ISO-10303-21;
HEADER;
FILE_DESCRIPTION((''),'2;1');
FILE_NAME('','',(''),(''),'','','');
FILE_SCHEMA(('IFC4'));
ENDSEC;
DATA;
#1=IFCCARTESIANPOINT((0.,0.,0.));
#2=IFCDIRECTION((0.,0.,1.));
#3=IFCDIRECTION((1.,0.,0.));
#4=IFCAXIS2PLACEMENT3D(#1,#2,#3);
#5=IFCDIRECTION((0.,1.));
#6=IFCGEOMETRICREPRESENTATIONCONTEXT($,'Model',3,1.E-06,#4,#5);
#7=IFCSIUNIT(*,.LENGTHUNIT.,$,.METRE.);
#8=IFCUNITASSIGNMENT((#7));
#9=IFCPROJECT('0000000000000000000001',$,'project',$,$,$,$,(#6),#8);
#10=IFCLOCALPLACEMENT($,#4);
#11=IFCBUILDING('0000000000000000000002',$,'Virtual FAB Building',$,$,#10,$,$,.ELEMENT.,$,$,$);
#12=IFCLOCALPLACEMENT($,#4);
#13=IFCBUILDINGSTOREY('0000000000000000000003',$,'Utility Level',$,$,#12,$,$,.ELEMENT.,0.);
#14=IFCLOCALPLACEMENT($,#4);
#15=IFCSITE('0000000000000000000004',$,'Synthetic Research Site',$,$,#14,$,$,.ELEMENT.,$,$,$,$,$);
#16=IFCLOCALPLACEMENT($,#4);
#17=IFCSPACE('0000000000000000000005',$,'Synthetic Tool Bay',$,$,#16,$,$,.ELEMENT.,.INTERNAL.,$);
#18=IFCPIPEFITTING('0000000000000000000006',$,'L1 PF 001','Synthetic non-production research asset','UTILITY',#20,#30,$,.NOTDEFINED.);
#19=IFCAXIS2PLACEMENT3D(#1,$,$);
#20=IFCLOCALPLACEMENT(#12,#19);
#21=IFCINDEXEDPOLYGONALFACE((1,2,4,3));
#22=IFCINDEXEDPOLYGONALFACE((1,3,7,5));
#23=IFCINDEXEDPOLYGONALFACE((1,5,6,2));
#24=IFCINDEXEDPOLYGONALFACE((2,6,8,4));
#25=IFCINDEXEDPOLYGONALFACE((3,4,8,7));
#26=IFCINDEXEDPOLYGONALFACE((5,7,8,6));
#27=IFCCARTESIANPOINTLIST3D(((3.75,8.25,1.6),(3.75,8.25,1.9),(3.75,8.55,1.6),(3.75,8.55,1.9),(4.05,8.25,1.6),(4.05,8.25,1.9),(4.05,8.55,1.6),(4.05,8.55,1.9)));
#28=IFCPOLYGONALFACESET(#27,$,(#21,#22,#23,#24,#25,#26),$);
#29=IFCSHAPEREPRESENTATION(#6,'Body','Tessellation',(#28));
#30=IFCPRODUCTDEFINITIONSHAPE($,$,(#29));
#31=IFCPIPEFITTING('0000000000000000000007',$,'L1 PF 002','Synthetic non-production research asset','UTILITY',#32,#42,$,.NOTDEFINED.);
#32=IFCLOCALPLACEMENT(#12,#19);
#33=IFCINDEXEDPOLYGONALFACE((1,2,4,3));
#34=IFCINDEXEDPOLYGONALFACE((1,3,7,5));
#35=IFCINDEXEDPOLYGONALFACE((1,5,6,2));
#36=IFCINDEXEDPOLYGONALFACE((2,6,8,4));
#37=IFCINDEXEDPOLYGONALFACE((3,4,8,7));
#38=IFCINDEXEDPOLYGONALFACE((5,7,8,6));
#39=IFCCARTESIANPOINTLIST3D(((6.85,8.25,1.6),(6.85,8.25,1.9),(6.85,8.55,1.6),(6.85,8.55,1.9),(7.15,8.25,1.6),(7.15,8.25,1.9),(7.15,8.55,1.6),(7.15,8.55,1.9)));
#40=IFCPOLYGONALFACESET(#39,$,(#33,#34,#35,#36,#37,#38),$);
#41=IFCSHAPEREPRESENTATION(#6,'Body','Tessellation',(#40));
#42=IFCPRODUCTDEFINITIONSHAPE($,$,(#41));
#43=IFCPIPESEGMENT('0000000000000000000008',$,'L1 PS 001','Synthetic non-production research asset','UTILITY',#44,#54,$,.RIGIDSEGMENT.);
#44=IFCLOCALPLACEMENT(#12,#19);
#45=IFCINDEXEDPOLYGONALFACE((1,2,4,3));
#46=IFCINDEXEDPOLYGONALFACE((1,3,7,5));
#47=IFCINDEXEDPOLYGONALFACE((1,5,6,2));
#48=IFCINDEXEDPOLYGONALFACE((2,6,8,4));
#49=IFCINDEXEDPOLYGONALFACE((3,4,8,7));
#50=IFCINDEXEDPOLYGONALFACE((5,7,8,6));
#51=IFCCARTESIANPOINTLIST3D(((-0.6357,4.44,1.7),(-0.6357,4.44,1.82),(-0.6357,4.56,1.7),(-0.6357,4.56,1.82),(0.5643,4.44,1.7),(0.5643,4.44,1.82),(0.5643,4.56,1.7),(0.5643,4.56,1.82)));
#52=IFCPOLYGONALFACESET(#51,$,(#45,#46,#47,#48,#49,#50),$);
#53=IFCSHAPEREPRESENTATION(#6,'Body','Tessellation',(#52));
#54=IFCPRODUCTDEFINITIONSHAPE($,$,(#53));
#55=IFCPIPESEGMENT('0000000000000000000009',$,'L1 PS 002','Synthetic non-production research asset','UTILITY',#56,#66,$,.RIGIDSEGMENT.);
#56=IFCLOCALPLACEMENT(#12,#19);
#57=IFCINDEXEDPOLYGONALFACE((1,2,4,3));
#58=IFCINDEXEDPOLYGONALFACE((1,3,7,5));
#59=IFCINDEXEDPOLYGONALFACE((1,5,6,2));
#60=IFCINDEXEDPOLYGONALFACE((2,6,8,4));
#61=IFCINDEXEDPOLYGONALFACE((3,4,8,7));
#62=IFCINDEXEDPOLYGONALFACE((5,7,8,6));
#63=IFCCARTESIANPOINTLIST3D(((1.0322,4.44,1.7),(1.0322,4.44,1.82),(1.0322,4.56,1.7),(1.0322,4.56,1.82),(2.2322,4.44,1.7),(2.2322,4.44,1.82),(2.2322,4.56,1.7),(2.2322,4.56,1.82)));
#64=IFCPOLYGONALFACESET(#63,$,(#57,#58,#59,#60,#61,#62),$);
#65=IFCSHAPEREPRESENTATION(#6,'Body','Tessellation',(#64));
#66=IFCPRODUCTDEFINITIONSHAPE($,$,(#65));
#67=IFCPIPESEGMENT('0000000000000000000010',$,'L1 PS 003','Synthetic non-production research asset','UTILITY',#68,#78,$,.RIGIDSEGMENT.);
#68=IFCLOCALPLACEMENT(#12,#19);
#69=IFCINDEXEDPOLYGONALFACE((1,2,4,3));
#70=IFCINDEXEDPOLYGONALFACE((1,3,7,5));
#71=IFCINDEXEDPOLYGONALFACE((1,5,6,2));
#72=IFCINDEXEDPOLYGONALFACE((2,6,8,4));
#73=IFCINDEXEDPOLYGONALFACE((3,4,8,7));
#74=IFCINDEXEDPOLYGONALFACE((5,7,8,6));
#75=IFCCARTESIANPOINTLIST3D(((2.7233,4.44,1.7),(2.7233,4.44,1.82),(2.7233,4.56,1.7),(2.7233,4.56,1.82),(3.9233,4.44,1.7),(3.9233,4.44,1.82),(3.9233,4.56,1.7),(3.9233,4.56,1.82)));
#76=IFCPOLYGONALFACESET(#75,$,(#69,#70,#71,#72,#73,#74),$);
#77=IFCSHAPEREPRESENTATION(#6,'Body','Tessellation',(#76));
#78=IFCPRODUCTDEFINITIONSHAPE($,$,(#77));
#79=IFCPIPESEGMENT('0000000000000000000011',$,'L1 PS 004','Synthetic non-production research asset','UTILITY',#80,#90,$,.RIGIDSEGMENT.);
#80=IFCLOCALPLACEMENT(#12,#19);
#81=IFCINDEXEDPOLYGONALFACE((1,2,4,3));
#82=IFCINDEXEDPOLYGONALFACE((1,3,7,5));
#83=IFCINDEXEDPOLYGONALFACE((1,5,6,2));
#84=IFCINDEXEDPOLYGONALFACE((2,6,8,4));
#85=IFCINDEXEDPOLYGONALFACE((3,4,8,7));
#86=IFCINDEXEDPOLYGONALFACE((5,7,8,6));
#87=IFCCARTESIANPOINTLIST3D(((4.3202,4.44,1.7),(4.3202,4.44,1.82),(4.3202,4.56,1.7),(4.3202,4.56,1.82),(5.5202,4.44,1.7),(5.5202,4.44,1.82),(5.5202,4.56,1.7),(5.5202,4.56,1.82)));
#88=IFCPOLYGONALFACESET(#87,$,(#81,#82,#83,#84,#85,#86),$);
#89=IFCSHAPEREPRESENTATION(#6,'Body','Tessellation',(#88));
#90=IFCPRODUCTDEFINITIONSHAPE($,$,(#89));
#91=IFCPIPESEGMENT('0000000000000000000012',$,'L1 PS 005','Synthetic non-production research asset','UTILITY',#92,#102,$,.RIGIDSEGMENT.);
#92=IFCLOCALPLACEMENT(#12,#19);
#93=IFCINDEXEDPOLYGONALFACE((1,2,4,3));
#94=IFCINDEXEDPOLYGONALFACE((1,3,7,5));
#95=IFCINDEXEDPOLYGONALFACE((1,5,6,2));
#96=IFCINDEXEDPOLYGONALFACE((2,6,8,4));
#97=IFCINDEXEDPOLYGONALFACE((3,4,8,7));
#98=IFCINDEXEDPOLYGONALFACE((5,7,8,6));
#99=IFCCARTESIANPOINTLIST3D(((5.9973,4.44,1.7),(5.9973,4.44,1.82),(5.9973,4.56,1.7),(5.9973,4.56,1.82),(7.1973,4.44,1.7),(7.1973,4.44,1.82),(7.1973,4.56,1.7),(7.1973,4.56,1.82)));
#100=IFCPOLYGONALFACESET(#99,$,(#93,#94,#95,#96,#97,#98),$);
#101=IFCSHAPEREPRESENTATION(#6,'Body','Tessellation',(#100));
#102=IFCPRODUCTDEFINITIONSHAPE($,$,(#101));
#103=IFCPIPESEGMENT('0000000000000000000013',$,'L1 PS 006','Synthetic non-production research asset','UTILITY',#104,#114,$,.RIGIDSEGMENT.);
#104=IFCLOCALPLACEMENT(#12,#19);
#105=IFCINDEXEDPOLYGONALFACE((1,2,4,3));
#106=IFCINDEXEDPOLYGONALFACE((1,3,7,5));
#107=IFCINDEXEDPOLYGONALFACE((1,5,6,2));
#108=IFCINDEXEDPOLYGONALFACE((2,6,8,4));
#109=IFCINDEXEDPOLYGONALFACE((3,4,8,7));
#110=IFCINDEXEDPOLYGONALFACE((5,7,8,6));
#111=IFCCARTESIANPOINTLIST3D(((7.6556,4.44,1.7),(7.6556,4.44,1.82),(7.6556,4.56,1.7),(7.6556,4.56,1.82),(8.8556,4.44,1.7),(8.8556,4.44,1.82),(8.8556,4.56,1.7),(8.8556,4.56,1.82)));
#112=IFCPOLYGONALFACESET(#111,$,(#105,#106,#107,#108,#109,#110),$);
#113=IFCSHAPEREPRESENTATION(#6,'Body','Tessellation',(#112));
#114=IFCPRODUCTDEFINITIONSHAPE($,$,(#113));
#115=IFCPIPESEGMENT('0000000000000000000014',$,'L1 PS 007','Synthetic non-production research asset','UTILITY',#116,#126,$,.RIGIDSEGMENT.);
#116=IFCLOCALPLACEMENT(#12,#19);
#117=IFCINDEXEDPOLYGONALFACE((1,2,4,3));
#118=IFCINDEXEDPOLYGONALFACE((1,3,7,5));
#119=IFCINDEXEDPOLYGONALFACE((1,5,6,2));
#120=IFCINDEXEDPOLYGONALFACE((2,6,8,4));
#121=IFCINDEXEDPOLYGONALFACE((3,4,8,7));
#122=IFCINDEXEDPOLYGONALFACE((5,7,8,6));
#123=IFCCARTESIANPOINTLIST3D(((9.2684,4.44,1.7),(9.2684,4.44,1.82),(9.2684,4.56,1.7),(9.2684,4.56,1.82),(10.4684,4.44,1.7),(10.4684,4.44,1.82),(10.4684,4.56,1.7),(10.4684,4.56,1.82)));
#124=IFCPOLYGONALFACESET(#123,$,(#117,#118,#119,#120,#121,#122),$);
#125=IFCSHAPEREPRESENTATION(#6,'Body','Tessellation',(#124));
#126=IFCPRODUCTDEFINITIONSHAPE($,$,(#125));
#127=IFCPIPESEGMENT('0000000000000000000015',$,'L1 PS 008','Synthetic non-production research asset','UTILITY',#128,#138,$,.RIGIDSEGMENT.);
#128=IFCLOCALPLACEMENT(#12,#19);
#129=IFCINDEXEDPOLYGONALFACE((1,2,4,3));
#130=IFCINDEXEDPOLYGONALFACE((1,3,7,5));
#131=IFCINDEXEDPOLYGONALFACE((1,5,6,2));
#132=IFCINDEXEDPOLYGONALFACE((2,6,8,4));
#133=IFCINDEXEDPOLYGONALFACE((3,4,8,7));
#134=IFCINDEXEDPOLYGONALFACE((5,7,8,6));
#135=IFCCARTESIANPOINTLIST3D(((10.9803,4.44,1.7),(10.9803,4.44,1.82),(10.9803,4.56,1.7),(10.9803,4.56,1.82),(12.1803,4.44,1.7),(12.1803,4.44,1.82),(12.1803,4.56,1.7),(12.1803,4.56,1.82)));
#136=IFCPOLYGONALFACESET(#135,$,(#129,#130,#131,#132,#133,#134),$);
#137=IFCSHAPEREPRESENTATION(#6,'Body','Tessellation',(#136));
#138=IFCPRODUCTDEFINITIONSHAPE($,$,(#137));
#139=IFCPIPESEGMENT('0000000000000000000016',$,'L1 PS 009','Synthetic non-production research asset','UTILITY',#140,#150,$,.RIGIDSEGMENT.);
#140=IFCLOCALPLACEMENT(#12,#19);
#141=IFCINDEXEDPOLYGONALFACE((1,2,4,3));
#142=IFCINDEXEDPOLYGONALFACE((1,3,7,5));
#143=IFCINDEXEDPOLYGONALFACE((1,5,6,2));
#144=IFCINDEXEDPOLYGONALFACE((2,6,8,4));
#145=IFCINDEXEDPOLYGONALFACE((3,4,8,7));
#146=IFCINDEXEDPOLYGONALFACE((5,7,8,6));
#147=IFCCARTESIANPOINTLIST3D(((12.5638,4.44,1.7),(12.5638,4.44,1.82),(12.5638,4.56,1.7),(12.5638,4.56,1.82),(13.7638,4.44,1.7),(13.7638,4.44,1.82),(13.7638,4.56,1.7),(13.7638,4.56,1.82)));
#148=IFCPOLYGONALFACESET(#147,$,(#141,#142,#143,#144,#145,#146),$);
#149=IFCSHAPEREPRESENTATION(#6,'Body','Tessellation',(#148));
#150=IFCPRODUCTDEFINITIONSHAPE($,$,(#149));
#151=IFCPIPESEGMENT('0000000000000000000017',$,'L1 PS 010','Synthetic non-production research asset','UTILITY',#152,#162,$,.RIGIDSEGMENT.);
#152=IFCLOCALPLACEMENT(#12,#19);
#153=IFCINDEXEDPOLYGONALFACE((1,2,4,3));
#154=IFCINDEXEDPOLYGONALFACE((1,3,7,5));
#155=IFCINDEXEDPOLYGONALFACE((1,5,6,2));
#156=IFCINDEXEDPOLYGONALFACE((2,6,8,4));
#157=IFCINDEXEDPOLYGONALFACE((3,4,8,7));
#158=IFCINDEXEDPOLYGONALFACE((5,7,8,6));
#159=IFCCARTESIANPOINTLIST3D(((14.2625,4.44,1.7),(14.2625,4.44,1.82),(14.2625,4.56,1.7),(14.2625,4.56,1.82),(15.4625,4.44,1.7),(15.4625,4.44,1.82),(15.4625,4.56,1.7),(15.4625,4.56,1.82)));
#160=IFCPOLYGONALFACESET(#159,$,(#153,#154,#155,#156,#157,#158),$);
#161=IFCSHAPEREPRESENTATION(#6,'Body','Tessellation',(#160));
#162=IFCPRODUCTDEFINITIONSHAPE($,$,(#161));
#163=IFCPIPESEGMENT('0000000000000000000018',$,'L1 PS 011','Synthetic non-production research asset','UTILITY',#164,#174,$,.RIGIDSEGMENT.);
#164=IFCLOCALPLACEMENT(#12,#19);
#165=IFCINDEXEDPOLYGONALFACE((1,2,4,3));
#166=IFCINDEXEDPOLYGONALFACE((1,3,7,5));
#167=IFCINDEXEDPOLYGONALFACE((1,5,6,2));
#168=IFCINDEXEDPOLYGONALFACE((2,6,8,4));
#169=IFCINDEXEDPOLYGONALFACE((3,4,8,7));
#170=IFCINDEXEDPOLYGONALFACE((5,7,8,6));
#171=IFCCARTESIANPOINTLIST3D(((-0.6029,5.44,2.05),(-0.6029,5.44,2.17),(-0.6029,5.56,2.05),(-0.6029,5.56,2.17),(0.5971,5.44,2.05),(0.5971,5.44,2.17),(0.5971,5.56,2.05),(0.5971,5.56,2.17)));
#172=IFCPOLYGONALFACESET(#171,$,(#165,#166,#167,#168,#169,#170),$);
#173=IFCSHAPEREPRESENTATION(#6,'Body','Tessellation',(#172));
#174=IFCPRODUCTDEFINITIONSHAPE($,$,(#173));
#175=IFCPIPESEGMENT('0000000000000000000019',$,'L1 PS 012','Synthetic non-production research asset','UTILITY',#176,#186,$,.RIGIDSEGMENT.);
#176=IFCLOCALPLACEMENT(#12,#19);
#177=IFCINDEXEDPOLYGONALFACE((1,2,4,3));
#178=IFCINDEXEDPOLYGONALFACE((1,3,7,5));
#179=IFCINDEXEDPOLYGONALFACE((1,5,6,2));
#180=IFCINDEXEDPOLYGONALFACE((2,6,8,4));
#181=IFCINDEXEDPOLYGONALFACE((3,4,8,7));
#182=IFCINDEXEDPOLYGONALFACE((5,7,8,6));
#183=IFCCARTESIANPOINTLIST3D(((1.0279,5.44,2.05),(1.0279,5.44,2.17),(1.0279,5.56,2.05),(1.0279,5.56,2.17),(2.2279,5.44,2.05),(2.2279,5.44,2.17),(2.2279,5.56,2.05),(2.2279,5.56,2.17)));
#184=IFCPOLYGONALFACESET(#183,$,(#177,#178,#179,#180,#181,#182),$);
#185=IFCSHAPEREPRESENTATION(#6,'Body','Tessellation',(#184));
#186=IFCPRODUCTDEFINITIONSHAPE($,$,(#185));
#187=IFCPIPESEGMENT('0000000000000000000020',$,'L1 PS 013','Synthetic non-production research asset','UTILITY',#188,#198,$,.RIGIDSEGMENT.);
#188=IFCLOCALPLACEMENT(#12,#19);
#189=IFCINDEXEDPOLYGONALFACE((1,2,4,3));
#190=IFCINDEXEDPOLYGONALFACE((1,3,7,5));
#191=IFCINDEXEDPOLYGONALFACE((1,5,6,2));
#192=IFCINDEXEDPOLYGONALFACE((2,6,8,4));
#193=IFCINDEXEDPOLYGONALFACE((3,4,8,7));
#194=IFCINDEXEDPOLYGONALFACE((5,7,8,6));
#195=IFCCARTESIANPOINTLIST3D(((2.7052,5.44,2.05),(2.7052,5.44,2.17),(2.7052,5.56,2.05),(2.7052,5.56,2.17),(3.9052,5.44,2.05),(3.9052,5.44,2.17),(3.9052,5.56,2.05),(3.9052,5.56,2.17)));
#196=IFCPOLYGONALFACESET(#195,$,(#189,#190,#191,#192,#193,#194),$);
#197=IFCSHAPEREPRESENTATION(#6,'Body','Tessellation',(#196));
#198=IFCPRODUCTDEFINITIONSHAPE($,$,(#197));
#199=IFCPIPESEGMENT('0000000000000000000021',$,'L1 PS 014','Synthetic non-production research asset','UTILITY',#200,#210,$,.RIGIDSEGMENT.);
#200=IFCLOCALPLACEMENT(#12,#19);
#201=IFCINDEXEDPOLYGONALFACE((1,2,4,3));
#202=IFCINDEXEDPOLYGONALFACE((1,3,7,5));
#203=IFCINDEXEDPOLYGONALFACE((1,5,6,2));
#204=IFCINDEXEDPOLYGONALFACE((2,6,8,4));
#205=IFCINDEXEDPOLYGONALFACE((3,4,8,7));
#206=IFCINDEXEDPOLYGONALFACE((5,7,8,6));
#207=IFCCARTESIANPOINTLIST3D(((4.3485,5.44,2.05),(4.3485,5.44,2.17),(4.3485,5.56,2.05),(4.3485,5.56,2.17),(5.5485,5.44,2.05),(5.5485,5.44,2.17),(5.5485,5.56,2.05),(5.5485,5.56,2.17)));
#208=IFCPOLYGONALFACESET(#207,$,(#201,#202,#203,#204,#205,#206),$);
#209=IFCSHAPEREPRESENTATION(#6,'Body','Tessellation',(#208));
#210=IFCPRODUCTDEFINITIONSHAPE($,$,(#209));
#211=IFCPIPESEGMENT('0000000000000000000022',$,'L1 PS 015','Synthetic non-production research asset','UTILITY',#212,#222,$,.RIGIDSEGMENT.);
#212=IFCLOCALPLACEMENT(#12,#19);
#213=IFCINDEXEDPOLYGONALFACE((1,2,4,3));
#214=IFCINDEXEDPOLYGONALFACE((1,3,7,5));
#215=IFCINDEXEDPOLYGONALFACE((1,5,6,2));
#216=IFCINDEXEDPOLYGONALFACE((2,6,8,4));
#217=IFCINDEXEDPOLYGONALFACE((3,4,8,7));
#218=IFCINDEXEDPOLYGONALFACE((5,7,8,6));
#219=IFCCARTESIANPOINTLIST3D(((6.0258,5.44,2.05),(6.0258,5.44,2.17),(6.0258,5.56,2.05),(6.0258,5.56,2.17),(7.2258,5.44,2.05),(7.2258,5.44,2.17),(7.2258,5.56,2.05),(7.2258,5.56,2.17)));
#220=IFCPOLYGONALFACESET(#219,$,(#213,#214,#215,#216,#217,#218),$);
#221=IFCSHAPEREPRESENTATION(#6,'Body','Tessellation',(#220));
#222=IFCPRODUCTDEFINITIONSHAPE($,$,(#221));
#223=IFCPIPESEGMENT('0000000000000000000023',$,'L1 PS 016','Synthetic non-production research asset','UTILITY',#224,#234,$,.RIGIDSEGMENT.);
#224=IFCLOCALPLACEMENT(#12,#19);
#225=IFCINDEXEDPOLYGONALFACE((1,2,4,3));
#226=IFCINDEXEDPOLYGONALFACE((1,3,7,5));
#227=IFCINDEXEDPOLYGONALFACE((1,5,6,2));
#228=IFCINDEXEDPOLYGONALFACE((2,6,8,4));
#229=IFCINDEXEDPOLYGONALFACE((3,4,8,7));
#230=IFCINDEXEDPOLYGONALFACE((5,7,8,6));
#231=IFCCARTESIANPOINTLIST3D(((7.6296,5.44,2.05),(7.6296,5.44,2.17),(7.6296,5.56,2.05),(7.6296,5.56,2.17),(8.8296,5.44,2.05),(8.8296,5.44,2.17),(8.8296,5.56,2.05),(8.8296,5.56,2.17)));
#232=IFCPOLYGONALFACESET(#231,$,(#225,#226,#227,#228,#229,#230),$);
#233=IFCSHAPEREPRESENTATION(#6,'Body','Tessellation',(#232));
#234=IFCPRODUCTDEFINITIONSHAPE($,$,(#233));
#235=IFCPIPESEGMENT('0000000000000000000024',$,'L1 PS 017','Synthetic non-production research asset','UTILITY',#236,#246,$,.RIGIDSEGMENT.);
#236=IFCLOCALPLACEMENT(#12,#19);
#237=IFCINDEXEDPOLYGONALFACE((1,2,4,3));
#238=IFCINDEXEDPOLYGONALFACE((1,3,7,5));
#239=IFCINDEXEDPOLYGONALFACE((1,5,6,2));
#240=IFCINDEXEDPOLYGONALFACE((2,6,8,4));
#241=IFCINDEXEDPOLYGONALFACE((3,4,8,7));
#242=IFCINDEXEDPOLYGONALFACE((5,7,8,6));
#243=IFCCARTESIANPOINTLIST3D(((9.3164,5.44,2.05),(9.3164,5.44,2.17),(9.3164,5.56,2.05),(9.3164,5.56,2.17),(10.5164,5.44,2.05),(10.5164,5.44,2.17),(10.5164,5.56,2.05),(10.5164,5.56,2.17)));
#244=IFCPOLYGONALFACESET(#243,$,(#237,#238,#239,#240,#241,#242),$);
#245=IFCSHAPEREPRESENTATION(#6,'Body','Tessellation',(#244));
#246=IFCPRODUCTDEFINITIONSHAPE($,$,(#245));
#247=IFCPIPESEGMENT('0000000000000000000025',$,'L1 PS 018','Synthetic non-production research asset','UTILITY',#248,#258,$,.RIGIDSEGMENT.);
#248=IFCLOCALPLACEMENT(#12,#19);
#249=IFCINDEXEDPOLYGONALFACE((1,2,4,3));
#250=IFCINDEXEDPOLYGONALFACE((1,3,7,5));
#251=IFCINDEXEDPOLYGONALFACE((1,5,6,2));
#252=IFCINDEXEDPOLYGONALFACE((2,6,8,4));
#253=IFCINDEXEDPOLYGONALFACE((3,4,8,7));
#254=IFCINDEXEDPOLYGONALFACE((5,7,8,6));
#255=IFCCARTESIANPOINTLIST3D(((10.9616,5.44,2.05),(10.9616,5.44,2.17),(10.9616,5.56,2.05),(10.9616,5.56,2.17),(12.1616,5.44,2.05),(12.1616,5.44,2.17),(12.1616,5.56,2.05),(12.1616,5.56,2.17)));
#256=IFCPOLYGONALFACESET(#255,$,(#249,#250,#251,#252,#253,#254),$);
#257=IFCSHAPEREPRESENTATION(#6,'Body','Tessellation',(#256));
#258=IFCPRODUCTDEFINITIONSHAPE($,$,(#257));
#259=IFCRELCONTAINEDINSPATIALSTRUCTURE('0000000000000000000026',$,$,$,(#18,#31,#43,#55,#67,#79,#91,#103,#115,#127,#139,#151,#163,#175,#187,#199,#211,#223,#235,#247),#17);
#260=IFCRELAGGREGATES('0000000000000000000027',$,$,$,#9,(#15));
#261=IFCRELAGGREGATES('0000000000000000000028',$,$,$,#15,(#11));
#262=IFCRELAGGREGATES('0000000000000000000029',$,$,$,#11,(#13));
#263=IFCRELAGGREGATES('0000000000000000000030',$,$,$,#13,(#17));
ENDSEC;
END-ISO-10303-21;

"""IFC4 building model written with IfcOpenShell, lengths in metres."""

from ifc_helpers import new_model, si_unit, direction, frame, origin_with_axes, origin_2d_with_axis, place, context, project, spatial, rectangle, extrude, element, save


model = new_model("IFC4")

# Units and contexts
model_context = context("Model", 3, precision=1e-06, world=origin_with_axes(), true_north=direction((0.0, 1.0)))
ifc_project = project(units=[si_unit("LENGTHUNIT", "METRE")], contexts=[model_context])

# Site, building, storey, space
site_placement = place(None, origin_with_axes())
site = spatial("IfcSite", under=ifc_project, at=site_placement, Name="Synthetic Research Site", CompositionType="ELEMENT")
building_placement = place(None, origin_with_axes())
building = spatial("IfcBuilding", under=site, at=building_placement, Name="Virtual FAB Building", CompositionType="ELEMENT")
storey_placement = place(None, origin_with_axes())
storey = spatial("IfcBuildingStorey", under=building, at=storey_placement, Name="Utility Level", CompositionType="ELEMENT", Elevation=0.0)
space_placement = place(None, origin_with_axes())
space = spatial("IfcSpace", under=storey, at=space_placement, Name="Synthetic Tool Bay", CompositionType="ELEMENT", PredefinedType="INTERNAL")

# Pipe fittings
for number, where, z_axis, x_axis, name in (
    (1, (3.9, 8.4, 1.6), (0.0, 0.0, 1.0), (1.0, 0.0, 0.0), "L1 PF 001"),
    (2, (7.0, 8.4, 1.6), (0.0, 0.0, 1.0), (1.0, 0.0, 0.0), "L1 PF 002"),
):
    element("IfcPipeFitting", number, at=place(None, frame(where, z_axis=z_axis, x_axis=x_axis)), inside=space, Name=name, Description="Synthetic non-production research asset", ObjectType="UTILITY", PredefinedType="NOTDEFINED", context=model_context, shape_type="SweptSolid", body=[
        extrude(rectangle(XDim=0.3, YDim=0.3, at=origin_2d_with_axis()), origin_with_axes(), (0.0, 0.0, 1.0), 0.3),
    ])

# Pipe segments
for number, where, z_axis, x_axis, name in (
    (3, (-0.0357, 4.5, 1.7), (0.0, 0.0, 1.0), (1.0, 0.0, 0.0), "L1 PS 001"),
    (4, (1.6322, 4.5, 1.7), (0.0, 0.0, 1.0), (1.0, 0.0, 0.0), "L1 PS 002"),
    (5, (3.3233, 4.5, 1.7), (0.0, 0.0, 1.0), (1.0, 0.0, 0.0), "L1 PS 003"),
    (6, (4.9202, 4.5, 1.7), (0.0, 0.0, 1.0), (1.0, 0.0, 0.0), "L1 PS 004"),
    (7, (6.5973, 4.5, 1.7), (0.0, 0.0, 1.0), (1.0, 0.0, 0.0), "L1 PS 005"),
    (8, (8.2556, 4.5, 1.7), (0.0, 0.0, 1.0), (1.0, 0.0, 0.0), "L1 PS 006"),
    (9, (9.8684, 4.5, 1.7), (0.0, 0.0, 1.0), (1.0, 0.0, 0.0), "L1 PS 007"),
    (10, (11.5803, 4.5, 1.7), (0.0, 0.0, 1.0), (1.0, 0.0, 0.0), "L1 PS 008"),
    (11, (13.1638, 4.5, 1.7), (0.0, 0.0, 1.0), (1.0, 0.0, 0.0), "L1 PS 009"),
    (12, (14.8625, 4.5, 1.7), (0.0, 0.0, 1.0), (1.0, 0.0, 0.0), "L1 PS 010"),
    (13, (-0.0029, 5.5, 2.05), (0.0, 0.0, 1.0), (1.0, 0.0, 0.0), "L1 PS 011"),
    (14, (1.6279, 5.5, 2.05), (0.0, 0.0, 1.0), (1.0, 0.0, 0.0), "L1 PS 012"),
    (15, (3.3053, 5.5, 2.05), (0.0, 0.0, 1.0), (1.0, 0.0, 0.0), "L1 PS 013"),
    (16, (4.9485, 5.5, 2.05), (0.0, 0.0, 1.0), (1.0, 0.0, 0.0), "L1 PS 014"),
    (17, (6.6258, 5.5, 2.05), (0.0, 0.0, 1.0), (1.0, 0.0, 0.0), "L1 PS 015"),
    (18, (8.2296, 5.5, 2.05), (0.0, 0.0, 1.0), (1.0, 0.0, 0.0), "L1 PS 016"),
    (19, (9.9164, 5.5, 2.05), (0.0, 0.0, 1.0), (1.0, 0.0, 0.0), "L1 PS 017"),
    (20, (11.5616, 5.5, 2.05), (0.0, 0.0, 1.0), (1.0, 0.0, 0.0), "L1 PS 018"),
):
    element("IfcPipeSegment", number, at=place(None, frame(where, z_axis=z_axis, x_axis=x_axis)), inside=space, Name=name, Description="Synthetic non-production research asset", ObjectType="UTILITY", PredefinedType="RIGIDSEGMENT", context=model_context, shape_type="SweptSolid", body=[
        extrude(rectangle(XDim=1.2, YDim=0.12, at=origin_2d_with_axis()), origin_with_axes(), (0.0, 0.0, 1.0), 0.12),
    ])

save(model, "model.ifc")
